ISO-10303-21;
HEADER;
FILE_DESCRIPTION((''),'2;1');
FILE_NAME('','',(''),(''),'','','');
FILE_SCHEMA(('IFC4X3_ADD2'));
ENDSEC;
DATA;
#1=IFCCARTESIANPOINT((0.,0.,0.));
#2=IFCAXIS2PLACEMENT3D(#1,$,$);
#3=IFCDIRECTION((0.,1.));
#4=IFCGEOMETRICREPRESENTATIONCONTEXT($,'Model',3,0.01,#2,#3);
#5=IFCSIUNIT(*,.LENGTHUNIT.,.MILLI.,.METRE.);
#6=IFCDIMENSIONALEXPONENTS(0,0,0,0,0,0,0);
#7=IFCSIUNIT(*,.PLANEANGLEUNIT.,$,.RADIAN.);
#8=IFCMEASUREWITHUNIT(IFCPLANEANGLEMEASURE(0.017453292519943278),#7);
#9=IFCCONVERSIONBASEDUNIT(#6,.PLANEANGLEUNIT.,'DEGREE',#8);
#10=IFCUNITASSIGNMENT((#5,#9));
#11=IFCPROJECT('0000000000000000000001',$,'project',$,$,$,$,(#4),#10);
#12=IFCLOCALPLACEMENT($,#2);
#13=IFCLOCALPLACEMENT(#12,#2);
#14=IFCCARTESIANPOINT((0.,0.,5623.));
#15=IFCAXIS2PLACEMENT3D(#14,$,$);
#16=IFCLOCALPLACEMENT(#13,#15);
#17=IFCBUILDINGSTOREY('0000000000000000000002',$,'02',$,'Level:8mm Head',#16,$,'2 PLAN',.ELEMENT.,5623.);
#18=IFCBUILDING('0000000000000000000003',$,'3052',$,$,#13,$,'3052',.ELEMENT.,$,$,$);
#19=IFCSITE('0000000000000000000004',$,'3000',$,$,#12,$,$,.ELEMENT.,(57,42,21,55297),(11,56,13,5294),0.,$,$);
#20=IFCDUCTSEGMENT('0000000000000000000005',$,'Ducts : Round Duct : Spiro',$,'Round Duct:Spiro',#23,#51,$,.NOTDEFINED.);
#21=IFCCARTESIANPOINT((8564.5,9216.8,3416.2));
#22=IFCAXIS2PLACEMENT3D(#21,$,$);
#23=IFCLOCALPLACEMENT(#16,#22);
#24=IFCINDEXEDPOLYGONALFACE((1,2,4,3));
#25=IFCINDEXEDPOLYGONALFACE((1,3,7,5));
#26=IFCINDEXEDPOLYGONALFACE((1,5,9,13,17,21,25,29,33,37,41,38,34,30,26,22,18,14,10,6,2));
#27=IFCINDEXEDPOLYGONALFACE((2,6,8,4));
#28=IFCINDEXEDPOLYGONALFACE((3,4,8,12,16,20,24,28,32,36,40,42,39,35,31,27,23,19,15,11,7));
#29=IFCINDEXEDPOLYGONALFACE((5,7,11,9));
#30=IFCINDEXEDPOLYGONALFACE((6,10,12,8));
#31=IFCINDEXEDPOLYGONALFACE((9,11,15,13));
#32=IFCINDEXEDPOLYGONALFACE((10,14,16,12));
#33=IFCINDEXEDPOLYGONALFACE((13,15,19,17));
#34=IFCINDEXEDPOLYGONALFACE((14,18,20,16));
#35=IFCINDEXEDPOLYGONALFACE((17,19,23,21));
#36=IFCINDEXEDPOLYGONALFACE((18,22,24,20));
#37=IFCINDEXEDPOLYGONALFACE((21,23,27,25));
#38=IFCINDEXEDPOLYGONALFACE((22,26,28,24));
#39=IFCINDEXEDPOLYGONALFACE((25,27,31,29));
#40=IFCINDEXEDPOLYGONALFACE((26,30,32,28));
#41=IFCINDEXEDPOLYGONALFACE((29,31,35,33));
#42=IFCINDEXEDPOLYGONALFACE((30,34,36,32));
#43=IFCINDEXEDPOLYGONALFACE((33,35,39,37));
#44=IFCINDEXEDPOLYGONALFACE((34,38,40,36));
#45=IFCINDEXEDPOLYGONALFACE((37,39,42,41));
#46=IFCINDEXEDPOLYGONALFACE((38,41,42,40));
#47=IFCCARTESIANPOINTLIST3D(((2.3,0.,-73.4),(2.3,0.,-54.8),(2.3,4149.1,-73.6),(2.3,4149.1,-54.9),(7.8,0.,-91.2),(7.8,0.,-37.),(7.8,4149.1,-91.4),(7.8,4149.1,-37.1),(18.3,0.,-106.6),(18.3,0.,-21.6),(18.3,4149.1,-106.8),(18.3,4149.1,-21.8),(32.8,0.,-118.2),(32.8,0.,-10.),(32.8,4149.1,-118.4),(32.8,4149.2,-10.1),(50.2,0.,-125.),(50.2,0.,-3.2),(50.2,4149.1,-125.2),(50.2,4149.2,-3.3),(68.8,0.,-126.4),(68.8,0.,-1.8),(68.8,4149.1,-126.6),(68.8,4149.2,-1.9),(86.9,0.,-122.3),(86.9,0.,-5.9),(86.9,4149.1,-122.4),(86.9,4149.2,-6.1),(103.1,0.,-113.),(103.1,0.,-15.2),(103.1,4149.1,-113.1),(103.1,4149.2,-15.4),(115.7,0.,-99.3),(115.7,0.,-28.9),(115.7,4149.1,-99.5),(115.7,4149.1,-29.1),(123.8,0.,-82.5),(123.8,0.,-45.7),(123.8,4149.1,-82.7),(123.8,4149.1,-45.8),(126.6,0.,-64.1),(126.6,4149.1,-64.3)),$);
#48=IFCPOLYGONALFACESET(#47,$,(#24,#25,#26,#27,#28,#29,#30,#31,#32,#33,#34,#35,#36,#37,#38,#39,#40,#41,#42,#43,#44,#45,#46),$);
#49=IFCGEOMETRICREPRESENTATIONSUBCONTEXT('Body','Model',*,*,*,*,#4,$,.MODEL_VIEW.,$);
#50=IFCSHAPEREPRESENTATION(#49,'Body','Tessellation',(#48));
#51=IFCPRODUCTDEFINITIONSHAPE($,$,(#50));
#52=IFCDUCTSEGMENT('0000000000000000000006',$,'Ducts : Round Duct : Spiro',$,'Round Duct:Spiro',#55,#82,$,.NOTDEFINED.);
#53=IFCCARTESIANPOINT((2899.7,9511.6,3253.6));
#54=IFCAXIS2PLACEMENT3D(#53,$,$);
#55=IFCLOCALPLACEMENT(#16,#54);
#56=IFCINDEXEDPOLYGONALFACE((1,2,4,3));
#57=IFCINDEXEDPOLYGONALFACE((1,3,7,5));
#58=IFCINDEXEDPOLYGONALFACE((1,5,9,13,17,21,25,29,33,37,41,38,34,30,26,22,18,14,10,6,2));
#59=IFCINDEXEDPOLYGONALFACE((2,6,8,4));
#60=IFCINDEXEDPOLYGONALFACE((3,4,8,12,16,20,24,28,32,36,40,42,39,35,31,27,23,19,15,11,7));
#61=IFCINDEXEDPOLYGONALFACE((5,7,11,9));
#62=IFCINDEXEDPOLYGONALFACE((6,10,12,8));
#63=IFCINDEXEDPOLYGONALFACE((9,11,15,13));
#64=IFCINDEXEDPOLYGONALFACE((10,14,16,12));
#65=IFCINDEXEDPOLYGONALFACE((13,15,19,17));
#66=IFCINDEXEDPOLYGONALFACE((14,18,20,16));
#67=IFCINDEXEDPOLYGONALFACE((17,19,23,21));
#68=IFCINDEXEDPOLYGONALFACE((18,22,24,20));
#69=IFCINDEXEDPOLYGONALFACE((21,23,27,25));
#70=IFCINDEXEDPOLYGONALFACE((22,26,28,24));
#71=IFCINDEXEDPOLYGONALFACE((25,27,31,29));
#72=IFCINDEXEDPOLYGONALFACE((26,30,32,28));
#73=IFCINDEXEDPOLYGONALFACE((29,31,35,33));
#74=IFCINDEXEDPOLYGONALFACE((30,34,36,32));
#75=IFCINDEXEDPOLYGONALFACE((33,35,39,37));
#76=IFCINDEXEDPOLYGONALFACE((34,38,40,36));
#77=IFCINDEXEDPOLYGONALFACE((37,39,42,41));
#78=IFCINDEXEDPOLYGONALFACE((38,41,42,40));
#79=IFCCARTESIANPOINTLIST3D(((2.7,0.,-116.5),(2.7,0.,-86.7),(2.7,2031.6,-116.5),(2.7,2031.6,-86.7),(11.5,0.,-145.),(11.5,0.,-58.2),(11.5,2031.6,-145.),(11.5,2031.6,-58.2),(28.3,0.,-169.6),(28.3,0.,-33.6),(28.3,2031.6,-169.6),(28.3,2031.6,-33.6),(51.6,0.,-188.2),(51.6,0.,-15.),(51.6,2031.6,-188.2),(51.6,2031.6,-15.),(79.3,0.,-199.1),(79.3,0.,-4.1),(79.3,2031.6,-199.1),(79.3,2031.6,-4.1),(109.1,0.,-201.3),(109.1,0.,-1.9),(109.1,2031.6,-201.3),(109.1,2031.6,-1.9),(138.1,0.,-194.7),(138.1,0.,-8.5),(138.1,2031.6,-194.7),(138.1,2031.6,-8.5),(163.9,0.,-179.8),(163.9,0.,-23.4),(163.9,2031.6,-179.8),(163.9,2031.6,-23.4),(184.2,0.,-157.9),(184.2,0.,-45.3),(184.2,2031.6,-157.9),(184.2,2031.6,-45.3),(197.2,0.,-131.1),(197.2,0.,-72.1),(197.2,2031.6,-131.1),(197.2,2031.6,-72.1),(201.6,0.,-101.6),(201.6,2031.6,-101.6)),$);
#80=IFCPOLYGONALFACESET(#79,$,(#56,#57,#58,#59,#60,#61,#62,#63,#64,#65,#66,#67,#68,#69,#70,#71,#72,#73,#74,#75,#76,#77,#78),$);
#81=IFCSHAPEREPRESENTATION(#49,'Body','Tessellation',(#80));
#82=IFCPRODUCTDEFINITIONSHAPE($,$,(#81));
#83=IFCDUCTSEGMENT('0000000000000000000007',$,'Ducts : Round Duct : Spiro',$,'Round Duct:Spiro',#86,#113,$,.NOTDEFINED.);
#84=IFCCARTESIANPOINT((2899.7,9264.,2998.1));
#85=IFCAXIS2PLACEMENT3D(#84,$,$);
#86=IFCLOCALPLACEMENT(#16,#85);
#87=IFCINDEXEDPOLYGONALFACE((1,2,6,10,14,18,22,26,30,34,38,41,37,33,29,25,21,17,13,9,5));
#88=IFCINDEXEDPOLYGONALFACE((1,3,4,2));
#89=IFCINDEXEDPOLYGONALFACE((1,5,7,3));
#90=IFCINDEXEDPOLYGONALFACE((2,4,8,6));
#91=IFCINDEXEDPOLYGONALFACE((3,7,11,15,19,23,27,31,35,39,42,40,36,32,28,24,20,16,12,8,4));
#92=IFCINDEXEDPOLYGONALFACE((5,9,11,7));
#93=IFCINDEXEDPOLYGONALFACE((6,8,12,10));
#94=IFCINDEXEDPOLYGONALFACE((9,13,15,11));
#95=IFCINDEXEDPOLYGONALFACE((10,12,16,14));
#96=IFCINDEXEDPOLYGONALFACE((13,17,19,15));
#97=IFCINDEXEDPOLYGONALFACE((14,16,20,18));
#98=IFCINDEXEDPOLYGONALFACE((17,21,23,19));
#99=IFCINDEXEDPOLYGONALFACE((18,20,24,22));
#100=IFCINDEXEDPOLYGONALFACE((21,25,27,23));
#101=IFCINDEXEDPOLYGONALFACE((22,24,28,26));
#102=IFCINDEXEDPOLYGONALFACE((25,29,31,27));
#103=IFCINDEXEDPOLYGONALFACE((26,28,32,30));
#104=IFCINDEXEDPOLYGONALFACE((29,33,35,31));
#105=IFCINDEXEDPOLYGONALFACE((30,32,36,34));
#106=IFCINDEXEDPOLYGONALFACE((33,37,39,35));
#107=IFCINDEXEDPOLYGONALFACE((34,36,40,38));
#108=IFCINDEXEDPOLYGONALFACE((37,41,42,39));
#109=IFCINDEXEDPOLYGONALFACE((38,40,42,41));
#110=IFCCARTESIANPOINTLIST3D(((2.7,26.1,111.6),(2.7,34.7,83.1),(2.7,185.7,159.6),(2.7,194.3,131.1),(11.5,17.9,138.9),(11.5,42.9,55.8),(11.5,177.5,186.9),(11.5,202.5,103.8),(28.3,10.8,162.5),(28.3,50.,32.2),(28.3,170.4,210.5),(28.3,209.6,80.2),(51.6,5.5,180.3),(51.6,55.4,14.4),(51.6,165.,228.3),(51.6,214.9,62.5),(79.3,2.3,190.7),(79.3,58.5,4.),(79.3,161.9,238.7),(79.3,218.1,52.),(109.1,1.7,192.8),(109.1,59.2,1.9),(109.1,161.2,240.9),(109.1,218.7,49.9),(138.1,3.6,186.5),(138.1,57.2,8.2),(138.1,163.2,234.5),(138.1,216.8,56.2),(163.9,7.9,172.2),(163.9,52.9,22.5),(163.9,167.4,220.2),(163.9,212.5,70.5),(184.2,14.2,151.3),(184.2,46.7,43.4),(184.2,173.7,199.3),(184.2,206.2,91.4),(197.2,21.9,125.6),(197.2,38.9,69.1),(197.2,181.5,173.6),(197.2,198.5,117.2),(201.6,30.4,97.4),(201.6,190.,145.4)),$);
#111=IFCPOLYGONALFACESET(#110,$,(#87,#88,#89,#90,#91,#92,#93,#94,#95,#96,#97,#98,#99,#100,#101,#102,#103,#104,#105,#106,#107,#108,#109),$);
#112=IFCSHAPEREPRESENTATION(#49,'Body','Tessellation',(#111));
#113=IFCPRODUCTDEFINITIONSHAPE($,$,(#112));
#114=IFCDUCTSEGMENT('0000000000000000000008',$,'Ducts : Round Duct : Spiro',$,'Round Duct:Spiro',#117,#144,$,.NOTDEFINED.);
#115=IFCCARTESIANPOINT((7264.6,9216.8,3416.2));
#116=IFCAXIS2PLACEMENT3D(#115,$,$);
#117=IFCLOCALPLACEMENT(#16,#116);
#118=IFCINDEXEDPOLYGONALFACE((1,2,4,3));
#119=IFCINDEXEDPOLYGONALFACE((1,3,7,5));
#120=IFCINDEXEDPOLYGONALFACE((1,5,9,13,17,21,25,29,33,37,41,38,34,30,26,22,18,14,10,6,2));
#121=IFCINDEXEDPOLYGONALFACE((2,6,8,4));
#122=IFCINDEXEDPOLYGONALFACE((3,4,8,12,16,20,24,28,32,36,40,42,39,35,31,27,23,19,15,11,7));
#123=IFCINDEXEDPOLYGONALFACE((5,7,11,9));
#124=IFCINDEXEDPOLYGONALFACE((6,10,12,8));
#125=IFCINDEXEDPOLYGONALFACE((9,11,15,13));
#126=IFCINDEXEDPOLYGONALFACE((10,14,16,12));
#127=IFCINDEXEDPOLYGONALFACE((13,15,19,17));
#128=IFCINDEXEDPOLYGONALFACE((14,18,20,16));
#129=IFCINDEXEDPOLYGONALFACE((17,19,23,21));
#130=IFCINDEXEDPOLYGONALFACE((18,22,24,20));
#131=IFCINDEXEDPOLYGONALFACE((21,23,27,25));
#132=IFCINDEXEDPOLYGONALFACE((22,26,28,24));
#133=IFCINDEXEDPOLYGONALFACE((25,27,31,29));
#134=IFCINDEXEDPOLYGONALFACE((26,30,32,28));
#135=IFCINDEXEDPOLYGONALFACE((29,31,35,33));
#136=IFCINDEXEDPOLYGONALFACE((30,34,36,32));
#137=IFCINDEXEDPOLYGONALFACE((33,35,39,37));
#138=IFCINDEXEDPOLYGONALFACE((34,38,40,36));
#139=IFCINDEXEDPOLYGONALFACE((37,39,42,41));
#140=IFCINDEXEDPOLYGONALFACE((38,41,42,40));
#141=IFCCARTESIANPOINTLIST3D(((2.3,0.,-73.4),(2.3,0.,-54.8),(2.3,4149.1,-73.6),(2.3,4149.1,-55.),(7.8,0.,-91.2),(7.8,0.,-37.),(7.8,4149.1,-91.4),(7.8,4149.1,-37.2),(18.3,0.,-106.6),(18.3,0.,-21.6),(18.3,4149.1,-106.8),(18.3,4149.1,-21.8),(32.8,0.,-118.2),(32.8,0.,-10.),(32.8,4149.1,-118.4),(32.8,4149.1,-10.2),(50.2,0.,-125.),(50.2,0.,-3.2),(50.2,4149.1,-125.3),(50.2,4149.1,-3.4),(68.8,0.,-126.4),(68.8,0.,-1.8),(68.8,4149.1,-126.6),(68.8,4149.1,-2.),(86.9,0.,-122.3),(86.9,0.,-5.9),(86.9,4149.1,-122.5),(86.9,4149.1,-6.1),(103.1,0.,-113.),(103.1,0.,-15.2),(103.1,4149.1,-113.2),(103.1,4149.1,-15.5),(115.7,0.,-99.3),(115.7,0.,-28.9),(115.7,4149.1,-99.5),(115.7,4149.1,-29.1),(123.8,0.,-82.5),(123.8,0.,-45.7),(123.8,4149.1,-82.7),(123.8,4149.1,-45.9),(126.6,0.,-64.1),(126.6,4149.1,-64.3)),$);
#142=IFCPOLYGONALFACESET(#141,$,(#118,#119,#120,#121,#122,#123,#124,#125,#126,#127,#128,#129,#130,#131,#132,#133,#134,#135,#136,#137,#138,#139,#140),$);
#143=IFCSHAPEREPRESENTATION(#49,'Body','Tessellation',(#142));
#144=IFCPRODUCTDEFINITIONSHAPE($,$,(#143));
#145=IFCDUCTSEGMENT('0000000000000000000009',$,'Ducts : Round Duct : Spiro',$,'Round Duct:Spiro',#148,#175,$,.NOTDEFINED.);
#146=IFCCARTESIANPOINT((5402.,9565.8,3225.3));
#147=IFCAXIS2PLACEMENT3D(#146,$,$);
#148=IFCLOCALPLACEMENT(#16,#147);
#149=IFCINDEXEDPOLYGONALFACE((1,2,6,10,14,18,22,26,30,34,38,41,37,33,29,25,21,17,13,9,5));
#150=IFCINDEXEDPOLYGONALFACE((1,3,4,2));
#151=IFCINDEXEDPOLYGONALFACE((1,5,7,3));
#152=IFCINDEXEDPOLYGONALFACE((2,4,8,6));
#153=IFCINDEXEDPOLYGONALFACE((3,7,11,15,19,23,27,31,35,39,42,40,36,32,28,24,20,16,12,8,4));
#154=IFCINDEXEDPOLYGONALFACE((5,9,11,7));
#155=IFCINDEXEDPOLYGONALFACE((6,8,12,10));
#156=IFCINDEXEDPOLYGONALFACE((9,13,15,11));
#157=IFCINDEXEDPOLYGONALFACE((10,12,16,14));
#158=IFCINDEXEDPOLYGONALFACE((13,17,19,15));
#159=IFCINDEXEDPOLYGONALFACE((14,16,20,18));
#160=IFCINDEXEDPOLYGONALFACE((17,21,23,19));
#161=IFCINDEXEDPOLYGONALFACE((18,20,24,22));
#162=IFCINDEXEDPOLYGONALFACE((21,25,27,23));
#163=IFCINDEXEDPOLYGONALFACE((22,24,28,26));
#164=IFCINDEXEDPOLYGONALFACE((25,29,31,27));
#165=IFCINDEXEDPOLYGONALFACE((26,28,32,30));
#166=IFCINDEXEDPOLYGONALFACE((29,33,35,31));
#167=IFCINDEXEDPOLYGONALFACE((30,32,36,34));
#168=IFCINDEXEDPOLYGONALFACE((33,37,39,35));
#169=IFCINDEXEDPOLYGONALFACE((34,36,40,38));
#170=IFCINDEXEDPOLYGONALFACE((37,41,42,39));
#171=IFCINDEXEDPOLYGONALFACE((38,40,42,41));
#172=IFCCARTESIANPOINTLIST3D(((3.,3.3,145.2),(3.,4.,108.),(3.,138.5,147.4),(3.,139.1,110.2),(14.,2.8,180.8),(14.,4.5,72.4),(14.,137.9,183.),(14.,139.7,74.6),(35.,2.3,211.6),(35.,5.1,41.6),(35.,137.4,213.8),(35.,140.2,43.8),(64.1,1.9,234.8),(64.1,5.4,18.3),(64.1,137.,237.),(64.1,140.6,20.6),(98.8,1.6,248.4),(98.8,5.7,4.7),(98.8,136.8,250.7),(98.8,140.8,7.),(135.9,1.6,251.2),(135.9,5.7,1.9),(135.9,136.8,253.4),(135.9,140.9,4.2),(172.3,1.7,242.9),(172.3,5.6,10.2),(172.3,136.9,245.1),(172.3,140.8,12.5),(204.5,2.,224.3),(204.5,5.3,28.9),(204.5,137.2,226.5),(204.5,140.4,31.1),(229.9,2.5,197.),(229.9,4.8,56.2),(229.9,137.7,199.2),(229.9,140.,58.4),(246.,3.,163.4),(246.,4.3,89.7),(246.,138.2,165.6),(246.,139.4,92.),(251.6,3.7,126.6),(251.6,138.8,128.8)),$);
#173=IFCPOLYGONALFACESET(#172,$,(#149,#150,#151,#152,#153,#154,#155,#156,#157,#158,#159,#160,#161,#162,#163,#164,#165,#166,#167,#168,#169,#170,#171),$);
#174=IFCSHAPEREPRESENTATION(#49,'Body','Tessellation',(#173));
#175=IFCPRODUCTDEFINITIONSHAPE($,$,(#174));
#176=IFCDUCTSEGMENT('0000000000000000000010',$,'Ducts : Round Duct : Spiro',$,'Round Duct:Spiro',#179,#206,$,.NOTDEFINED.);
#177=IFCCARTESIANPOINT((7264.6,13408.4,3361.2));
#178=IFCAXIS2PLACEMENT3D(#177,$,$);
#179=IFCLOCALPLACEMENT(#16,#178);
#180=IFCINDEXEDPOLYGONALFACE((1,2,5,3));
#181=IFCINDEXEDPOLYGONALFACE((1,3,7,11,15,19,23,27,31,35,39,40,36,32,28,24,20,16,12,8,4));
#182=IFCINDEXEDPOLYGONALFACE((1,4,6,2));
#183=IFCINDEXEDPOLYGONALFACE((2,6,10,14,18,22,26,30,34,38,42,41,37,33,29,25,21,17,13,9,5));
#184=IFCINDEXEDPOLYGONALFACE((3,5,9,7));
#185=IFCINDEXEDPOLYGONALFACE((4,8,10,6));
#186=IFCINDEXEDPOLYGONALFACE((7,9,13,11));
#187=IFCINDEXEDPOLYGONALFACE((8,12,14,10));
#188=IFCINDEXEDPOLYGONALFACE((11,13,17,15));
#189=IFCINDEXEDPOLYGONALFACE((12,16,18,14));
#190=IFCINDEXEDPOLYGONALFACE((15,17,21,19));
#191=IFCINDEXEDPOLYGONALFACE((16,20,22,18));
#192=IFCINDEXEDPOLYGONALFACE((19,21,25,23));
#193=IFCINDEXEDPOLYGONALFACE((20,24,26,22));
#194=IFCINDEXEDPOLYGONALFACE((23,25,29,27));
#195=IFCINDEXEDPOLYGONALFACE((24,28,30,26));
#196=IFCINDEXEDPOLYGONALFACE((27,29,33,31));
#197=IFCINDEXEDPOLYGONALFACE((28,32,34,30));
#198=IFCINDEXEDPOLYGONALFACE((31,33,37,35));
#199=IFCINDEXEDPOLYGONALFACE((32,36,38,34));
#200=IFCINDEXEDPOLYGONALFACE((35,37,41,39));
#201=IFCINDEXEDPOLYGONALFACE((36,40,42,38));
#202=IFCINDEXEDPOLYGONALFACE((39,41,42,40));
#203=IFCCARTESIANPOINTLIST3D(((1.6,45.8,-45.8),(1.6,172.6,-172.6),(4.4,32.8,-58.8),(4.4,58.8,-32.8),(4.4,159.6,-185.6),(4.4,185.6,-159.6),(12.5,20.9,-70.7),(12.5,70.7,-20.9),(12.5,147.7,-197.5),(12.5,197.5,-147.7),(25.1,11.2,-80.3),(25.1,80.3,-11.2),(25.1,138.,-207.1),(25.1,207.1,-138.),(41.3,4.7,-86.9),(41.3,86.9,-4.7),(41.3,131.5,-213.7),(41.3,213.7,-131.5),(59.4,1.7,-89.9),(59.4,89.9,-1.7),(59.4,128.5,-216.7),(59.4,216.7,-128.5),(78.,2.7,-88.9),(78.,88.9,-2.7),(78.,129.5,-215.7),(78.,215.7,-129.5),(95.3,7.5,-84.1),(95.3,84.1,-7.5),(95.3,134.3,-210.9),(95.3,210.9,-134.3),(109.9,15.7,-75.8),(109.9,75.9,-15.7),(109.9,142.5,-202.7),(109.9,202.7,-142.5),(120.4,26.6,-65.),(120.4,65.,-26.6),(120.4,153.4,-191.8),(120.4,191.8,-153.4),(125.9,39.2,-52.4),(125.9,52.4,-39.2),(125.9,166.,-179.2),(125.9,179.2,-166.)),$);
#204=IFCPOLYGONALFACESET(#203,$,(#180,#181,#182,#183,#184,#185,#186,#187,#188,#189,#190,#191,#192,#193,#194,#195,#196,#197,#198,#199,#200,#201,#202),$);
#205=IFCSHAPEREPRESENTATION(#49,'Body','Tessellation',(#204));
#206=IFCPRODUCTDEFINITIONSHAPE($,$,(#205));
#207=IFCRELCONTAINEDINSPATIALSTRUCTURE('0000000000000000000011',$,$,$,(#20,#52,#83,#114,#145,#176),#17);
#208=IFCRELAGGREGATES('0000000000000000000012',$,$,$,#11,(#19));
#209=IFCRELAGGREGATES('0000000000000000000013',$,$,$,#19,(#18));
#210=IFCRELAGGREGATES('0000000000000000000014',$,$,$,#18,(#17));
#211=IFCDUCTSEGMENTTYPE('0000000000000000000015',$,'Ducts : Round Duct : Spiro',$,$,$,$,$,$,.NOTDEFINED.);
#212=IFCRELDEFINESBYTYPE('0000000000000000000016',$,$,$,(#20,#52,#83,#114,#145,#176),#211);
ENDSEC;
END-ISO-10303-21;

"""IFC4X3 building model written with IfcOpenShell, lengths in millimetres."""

from ifc_helpers import new_model, entity, si_unit, converted_unit, direction, frame, frame_2d, origin, place, context, subcontext, project, spatial, circle, extrude, type_object, element, save


model = new_model("IFC4X3")

# Units and contexts
model_context = context("Model", 3, precision=0.01, world=origin(), true_north=direction((0.0, 1.0)))
body_context = subcontext(model_context, "Body", "Model", "MODEL_VIEW")
ifc_project = project(units=[si_unit("LENGTHUNIT", "METRE", prefix="MILLI"), converted_unit("PLANEANGLEUNIT", "DEGREE", entity("IfcPlaneAngleMeasure", 0.017453292519943278), si_unit("PLANEANGLEUNIT", "RADIAN"), dimensions=[0, 0, 0, 0, 0, 0, 0])], contexts=[model_context])

# Site, building, storey
site_placement = place(None, origin())
site = spatial("IfcSite", under=ifc_project, at=site_placement, Name="3000", CompositionType="ELEMENT", RefLatitude=(57, 42, 21, 55297), RefLongitude=(11, 56, 13, 5294), RefElevation=0.0)
building_placement = place(site_placement, origin())
building = spatial("IfcBuilding", under=site, at=building_placement, Name="3052", LongName="3052", CompositionType="ELEMENT")
storey_placement = place(building_placement, frame((0.0, 0.0, 5623.0)))
storey = spatial("IfcBuildingStorey", under=building, at=storey_placement, Name="02", ObjectType="Level:8mm Head", LongName="2 PLAN", CompositionType="ELEMENT", Elevation=5623.0)

# Duct segments
duct_segment_type = type_object("IfcDuctSegmentType", Name="Ducts : Round Duct : Spiro", PredefinedType="NOTDEFINED")
duct_segment_1_placement = place(storey_placement, frame((8564.5, 9216.8, 3416.2)))
element("IfcDuctSegment", 1, at=duct_segment_1_placement, inside=storey, type_object=duct_segment_type, Name="Ducts : Round Duct : Spiro", ObjectType="Round Duct:Spiro", PredefinedType="NOTDEFINED", context=body_context, shape_type="SweptSolid", body=[
    extrude(circle(Radius=62.5, at=frame_2d((0.0, 0.0), x_axis=(1.0, 0.0))), frame((64.1, 0.0, -64.1), z_axis=(0.0, 1.0, -0.00004), x_axis=(1.0, 0.0, 0.0)), (0.0, 0.0, 1.0), 4149.1),
])
duct_segment_2_placement = place(storey_placement, frame((2899.7, 9511.6, 3253.6)))
element("IfcDuctSegment", 2, at=duct_segment_2_placement, inside=storey, type_object=duct_segment_type, Name="Ducts : Round Duct : Spiro", ObjectType="Round Duct:Spiro", PredefinedType="NOTDEFINED", context=body_context, shape_type="SweptSolid", body=[
    extrude(circle(Radius=100.0, at=frame_2d((0.0, 0.0), x_axis=(1.0, 0.0))), frame((101.6, 0.0, -101.6), z_axis=(0.0, 1.0, 0.0), x_axis=(1.0, 0.0, 0.0)), (0.0, 0.0, 1.0), 2031.6),
])
duct_segment_3_placement = place(storey_placement, frame((2899.7, 9264.0, 2998.1)))
element("IfcDuctSegment", 3, at=duct_segment_3_placement, inside=storey, type_object=duct_segment_type, Name="Ducts : Round Duct : Spiro", ObjectType="Round Duct:Spiro", PredefinedType="NOTDEFINED", context=body_context, shape_type="SweptSolid", body=[
    extrude(circle(Radius=100.0, at=frame_2d((0.0, 0.0), x_axis=(1.0, 0.0))), frame((101.6, 30.4, 97.4), z_axis=(0.0, 0.957567, 0.28821), x_axis=(1.0, 0.0, 0.0)), (0.0, 0.0, 1.0), 166.6),
])
duct_segment_4_placement = place(storey_placement, frame((7264.6, 9216.8, 3416.2)))
element("IfcDuctSegment", 4, at=duct_segment_4_placement, inside=storey, type_object=duct_segment_type, Name="Ducts : Round Duct : Spiro", ObjectType="Round Duct:Spiro", PredefinedType="NOTDEFINED", context=body_context, shape_type="SweptSolid", body=[
    extrude(circle(Radius=62.5, at=frame_2d((0.0, 0.0), x_axis=(1.0, 0.0))), frame((64.1, 0.0, -64.1), z_axis=(0.0, 1.0, -0.000054), x_axis=(1.0, 0.0, 0.0)), (0.0, 0.0, 1.0), 4149.1),
])
duct_segment_5_placement = place(storey_placement, frame((5402.0, 9565.8, 3225.3)))
element("IfcDuctSegment", 5, at=duct_segment_5_placement, inside=storey, type_object=duct_segment_type, Name="Ducts : Round Duct : Spiro", ObjectType="Round Duct:Spiro", PredefinedType="NOTDEFINED", context=body_context, shape_type="SweptSolid", body=[
    extrude(circle(Radius=125.0, at=frame_2d((0.0, 0.0), x_axis=(1.0, 0.0))), frame((126.6, 3.7, 126.6), z_axis=(0.0, 0.999864, 0.016479), x_axis=(1.0, 0.0, 0.0)), (0.0, 0.0, 1.0), 135.2),
])
duct_segment_6_placement = place(storey_placement, frame((7264.6, 13408.4, 3361.2)))
element("IfcDuctSegment", 6, at=duct_segment_6_placement, inside=storey, type_object=duct_segment_type, Name="Ducts : Round Duct : Spiro", ObjectType="Round Duct:Spiro", PredefinedType="NOTDEFINED", context=body_context, shape_type="SweptSolid", body=[
    extrude(circle(Radius=62.5, at=frame_2d((0.0, 0.0), x_axis=(1.0, 0.0))), frame((64.1, 172.6, -172.6), z_axis=(0.0, -0.707088, 0.707126), x_axis=(-1.0, 0.0, 0.0)), (0.0, 0.0, 1.0), 179.3),
])

save(model, "model.ifc")
